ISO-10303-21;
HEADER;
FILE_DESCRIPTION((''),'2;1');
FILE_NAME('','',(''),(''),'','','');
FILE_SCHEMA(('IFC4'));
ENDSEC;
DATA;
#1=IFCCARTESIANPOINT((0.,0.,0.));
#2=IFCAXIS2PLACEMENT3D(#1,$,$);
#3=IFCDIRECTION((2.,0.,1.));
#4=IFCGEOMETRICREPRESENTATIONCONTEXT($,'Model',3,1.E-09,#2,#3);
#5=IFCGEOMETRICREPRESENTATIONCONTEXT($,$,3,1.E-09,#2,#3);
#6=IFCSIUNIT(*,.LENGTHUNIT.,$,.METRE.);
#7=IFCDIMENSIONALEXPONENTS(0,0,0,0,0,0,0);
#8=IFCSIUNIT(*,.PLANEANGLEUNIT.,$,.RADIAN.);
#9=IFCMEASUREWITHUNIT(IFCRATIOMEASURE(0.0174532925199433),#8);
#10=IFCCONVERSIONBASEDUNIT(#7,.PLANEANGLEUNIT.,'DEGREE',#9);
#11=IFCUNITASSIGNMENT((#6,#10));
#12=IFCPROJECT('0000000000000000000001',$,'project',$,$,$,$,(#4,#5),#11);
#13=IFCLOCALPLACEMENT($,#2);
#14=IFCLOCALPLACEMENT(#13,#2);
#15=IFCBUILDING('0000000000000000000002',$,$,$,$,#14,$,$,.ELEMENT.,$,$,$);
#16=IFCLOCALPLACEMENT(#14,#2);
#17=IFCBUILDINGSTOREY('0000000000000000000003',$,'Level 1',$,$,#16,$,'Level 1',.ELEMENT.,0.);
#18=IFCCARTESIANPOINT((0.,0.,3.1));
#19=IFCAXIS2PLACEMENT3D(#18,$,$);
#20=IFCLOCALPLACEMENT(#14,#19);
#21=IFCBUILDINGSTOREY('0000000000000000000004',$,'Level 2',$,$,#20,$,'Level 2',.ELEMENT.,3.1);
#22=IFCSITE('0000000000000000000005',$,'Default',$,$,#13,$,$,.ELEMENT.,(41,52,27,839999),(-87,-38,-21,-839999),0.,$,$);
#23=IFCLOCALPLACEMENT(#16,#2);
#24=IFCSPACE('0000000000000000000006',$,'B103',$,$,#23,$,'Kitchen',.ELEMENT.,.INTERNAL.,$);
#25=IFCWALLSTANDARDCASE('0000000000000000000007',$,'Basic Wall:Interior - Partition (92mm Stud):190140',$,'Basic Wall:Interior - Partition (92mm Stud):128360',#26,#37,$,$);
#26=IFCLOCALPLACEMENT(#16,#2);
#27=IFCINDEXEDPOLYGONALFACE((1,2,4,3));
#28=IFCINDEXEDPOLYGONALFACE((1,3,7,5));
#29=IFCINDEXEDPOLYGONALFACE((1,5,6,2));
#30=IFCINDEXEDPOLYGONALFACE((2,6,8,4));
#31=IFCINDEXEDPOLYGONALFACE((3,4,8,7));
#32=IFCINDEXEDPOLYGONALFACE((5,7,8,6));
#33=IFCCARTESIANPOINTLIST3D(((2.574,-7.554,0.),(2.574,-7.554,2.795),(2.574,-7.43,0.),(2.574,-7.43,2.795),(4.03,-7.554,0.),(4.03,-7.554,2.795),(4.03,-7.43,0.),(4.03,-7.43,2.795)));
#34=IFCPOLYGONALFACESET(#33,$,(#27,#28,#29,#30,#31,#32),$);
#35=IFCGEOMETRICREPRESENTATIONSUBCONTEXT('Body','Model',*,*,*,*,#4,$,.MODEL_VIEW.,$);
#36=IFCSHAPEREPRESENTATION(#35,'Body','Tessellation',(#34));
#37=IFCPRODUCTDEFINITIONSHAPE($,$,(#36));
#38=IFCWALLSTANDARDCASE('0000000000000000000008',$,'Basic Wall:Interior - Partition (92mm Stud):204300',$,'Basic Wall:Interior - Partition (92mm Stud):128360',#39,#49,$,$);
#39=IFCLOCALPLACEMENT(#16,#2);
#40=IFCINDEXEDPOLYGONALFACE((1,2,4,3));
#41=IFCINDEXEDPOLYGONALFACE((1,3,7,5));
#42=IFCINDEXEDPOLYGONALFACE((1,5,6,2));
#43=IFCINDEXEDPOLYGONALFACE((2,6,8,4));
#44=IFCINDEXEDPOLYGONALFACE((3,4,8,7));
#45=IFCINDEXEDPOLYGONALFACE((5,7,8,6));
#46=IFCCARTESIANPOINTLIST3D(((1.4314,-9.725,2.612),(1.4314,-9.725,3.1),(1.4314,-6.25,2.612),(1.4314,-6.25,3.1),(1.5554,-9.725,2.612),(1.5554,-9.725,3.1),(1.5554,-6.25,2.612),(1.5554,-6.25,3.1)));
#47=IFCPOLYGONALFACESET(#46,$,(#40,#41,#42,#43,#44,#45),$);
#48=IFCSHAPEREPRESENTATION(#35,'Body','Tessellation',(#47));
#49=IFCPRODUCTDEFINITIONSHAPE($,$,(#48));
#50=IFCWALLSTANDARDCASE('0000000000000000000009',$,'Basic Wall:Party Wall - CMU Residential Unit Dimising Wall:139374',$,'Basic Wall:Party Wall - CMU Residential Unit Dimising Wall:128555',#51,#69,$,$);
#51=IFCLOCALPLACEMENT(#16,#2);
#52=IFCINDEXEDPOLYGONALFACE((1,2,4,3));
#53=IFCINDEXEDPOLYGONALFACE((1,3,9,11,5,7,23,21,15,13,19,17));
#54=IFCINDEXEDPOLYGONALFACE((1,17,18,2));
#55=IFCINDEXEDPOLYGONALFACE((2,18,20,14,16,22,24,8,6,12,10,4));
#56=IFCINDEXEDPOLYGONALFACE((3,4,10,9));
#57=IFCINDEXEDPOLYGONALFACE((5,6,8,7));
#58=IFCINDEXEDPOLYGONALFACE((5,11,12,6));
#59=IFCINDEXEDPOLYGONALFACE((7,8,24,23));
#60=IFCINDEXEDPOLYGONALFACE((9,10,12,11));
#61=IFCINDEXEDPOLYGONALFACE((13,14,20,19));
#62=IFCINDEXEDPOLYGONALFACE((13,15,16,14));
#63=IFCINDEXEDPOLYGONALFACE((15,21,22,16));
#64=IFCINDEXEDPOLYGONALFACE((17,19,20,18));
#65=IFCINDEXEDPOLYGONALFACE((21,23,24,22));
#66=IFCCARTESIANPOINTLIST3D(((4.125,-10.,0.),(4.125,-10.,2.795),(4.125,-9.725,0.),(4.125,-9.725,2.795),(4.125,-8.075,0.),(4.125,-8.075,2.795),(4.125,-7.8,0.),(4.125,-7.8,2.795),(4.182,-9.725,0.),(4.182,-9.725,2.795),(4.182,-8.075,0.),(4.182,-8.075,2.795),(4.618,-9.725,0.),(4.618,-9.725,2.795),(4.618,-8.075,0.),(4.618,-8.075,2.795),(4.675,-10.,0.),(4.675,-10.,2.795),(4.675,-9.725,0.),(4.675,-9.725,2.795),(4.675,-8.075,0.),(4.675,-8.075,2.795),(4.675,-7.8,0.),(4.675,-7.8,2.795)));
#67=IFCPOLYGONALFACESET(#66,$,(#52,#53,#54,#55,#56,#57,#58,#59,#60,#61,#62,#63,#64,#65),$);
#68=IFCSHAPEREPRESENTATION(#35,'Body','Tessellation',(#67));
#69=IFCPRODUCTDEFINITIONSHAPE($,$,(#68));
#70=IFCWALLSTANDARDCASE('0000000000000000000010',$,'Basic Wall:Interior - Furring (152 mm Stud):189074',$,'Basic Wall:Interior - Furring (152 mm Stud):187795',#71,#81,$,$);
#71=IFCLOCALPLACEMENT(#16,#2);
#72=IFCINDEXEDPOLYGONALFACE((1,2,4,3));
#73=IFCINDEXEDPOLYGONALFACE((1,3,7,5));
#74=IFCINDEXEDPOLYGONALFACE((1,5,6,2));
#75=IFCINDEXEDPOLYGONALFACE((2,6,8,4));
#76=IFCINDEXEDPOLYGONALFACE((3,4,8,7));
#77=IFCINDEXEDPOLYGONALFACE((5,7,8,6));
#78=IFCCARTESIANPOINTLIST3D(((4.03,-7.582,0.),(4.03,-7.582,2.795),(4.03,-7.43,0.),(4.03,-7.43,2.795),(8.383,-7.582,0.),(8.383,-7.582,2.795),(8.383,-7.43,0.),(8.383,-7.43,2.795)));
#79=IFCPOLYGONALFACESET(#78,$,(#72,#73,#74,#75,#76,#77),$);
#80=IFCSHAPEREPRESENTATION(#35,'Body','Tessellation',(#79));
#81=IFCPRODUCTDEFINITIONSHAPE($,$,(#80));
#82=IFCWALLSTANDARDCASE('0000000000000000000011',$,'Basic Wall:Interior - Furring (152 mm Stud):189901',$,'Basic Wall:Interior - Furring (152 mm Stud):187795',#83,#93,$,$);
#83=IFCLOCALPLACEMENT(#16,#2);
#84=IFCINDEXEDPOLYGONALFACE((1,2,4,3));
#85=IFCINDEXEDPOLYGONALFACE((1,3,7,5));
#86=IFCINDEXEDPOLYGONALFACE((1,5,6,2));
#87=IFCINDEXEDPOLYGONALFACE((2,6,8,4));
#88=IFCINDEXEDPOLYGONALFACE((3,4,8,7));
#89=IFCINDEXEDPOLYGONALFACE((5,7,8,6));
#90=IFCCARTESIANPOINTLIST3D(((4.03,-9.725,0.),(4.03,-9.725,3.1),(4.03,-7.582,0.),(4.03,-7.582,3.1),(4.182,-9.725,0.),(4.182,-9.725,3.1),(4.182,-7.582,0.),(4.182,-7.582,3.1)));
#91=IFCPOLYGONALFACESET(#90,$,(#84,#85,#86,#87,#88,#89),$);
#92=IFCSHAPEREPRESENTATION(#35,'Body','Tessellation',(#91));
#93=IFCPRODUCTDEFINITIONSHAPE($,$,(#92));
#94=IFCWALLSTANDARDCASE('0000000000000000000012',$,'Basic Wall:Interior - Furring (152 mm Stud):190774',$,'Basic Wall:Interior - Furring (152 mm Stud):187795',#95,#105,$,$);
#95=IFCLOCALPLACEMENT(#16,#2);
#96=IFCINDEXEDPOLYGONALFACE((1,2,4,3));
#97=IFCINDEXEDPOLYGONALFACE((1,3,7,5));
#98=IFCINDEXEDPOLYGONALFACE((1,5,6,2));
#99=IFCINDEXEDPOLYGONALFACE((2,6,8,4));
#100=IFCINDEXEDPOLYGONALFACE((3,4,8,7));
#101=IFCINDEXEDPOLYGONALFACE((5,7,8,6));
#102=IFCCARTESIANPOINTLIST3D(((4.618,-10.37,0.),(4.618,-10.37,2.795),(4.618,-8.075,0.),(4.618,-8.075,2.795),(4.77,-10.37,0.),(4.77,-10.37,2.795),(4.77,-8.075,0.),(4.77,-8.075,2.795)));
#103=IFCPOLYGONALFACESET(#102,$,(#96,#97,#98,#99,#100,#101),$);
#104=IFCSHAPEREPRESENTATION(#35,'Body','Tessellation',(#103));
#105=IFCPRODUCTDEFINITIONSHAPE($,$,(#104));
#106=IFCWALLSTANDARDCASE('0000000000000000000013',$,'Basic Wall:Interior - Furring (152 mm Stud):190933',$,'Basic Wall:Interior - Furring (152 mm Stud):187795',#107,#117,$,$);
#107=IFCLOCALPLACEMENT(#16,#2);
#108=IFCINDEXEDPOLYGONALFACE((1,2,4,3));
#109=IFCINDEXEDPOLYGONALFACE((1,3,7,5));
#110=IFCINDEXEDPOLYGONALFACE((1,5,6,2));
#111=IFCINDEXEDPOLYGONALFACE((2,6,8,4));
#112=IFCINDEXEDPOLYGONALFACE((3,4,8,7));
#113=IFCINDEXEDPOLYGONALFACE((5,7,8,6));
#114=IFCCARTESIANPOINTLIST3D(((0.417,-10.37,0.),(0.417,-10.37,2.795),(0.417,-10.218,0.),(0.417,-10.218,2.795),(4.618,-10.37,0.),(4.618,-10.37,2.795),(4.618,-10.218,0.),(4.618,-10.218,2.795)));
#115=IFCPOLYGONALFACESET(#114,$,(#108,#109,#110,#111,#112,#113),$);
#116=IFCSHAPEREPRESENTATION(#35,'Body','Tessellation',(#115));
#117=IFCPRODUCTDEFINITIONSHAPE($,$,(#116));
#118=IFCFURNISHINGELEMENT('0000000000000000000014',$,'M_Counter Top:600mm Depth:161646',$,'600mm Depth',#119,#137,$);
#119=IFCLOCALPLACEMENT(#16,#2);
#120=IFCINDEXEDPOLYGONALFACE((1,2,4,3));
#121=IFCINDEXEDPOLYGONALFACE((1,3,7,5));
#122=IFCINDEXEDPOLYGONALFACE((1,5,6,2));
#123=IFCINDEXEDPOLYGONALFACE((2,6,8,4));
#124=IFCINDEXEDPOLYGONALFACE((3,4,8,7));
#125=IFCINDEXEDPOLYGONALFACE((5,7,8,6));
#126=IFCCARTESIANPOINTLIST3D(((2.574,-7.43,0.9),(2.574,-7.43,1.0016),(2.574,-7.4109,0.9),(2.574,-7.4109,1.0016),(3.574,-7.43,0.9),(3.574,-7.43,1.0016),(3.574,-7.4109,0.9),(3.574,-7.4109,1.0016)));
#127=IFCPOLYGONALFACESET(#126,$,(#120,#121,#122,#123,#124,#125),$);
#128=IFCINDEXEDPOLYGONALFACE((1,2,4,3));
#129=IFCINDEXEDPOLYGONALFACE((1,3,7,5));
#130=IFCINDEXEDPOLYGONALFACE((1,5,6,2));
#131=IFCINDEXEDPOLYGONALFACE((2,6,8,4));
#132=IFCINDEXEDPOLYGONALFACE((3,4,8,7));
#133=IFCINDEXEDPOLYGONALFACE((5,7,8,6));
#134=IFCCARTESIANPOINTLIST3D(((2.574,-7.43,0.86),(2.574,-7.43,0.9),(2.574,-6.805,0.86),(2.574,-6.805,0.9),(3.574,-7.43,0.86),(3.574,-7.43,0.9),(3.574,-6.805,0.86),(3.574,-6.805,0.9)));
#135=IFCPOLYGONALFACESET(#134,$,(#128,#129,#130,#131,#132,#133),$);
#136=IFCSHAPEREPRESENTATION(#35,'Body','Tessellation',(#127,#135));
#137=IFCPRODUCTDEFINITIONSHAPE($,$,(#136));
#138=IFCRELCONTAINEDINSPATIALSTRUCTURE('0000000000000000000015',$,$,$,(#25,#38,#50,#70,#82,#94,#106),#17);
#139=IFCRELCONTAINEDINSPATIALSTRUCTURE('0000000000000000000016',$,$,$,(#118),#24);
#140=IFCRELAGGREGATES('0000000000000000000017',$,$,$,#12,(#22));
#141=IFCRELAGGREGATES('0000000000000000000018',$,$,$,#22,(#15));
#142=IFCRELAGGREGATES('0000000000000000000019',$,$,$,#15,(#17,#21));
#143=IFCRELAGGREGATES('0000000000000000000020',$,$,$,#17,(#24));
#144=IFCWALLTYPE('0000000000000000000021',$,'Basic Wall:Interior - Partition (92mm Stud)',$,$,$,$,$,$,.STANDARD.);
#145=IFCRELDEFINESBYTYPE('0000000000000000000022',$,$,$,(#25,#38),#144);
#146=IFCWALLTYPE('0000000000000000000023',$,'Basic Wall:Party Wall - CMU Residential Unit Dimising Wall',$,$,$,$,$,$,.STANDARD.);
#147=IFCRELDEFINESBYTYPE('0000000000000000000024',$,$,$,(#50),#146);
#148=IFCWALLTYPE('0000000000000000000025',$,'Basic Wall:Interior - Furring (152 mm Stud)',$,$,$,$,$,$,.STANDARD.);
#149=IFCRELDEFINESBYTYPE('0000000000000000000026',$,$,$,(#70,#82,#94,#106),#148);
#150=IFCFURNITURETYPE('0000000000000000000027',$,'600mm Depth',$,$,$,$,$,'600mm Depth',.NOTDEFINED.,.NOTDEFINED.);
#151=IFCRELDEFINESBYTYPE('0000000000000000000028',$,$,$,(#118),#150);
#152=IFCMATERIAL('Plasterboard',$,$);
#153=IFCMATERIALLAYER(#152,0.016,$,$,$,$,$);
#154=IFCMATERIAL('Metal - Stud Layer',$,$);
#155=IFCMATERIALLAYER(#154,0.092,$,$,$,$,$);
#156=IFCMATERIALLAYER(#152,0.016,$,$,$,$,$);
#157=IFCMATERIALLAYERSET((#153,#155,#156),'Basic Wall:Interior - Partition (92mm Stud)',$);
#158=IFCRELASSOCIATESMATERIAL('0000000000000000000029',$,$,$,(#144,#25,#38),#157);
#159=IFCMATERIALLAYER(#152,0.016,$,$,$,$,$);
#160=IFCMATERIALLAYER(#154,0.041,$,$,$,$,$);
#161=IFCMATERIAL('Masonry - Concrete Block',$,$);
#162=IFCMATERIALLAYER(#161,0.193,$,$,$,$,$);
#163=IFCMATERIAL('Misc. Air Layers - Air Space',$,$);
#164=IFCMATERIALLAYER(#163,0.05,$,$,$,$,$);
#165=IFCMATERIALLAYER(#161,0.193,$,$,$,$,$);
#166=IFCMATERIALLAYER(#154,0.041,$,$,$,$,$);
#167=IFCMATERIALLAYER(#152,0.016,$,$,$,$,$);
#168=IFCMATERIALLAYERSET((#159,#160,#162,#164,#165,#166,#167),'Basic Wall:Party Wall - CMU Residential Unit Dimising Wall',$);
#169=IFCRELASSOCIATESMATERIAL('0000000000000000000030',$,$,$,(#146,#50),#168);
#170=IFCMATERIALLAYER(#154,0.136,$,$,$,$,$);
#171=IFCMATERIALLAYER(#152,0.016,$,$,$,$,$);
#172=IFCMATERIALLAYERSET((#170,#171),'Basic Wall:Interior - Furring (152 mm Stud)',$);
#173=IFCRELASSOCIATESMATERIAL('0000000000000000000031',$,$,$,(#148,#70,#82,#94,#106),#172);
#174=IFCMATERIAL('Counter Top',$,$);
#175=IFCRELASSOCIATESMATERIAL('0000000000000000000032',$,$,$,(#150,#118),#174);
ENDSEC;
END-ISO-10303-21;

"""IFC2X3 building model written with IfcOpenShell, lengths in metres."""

from ifc_helpers import new_model, entity, si_unit, converted_unit, direction, frame, frame_2d, origin, place, context, subcontext, project, spatial, polyline, rectangle, extrude, clip, bounded_halfspace, source, transform, mapped, material, layer, layer_set, layer_usage, type_object, type_shapes, element, save


model = new_model("IFC2X3")

# Units and contexts
model_context = context("Model", 3, precision=1e-09, world=origin(), true_north=direction((2.0, 0.0, 1.0)))
context_of_model = context(None, 3, precision=1e-09, world=origin(), true_north=direction((2.0, 0.0, 1.0)))
body_context = subcontext(model_context, "Body", "Model", "MODEL_VIEW")
ifc_project = project(units=[si_unit("LENGTHUNIT", "METRE"), converted_unit("PLANEANGLEUNIT", "DEGREE", entity("IfcRatioMeasure", 0.0174532925199433), si_unit("PLANEANGLEUNIT", "RADIAN"), dimensions=[0, 0, 0, 0, 0, 0, 0])], contexts=[model_context, context_of_model])

# Site, building, storey
site_placement = place(None, origin())
site = spatial("IfcSite", under=ifc_project, at=site_placement, Name="Default", CompositionType="ELEMENT", RefLatitude=(41, 52, 27, 839999), RefLongitude=(-87, -38, -21, -839999), RefElevation=0.0)
building_placement = place(site_placement, origin())
building = spatial("IfcBuilding", under=site, at=building_placement, CompositionType="ELEMENT")
storey_1_placement = place(building_placement, origin())
storey_1 = spatial("IfcBuildingStorey", under=building, at=storey_1_placement, Name="Level 1", LongName="Level 1", CompositionType="ELEMENT", Elevation=0.0)

# Shared definitions
ifc_material_1 = material(Name="Plasterboard")
ifc_layer_1 = layer(ifc_material_1, 0.016)
ifc_material_2 = material(Name="Metal - Stud Layer")
ifc_layer_2 = layer(ifc_material_2, 0.092)
ifc_layer_3 = layer(ifc_material_1, 0.016)
ifc_layer_set_1 = layer_set([ifc_layer_1, ifc_layer_2, ifc_layer_3], Name="Basic Wall:Interior - Partition (92mm Stud)")
wall_type_1 = type_object("IfcWallType", Name="Basic Wall:Interior - Partition (92mm Stud)", PredefinedType="STANDARD", material=ifc_layer_set_1)

# Shared definitions
storey_2_placement = place(building_placement, frame((0.0, 0.0, 3.1)))
storey_2 = spatial("IfcBuildingStorey", under=building, at=storey_2_placement, Name="Level 2", LongName="Level 2", CompositionType="ELEMENT", Elevation=3.1)

# Walls
ifc_layer_usage_1 = layer_usage(ifc_layer_set_1, "AXIS2", "NEGATIVE", 0.062)
wall_1_placement = place(storey_1_placement, frame((4.03, -7.492, 0.0), z_axis=(0.0, 0.0, 1.0), x_axis=(-1.0, 0.0, 0.0)))
element("IfcWallStandardCase", 1, at=wall_1_placement, inside=storey_1, type_object=wall_type_1, material=ifc_layer_usage_1, Name="Basic Wall:Interior - Partition (92mm Stud):190140", ObjectType="Basic Wall:Interior - Partition (92mm Stud):128360", context=body_context, shape_type="SweptSolid", body=[
    extrude(rectangle(XDim=1.456, YDim=0.124, at=frame_2d((0.728, 0.0), x_axis=(-1.0, 0.0))), origin(), (0.0, 0.0, 1.0), 2.795),
])
ifc_layer_usage_2 = layer_usage(ifc_layer_set_1, "AXIS2", "NEGATIVE", 0.062)
wall_2_placement = place(storey_1_placement, frame((1.4934, -6.25, 2.612), z_axis=(0.0, 0.0, 1.0), x_axis=(0.0, -1.0, 0.0)))
element("IfcWallStandardCase", 2, at=wall_2_placement, inside=storey_1, type_object=wall_type_1, material=ifc_layer_usage_2, Name="Basic Wall:Interior - Partition (92mm Stud):204300", ObjectType="Basic Wall:Interior - Partition (92mm Stud):128360", context=body_context, shape_type="SweptSolid", body=[
    extrude(rectangle(XDim=3.475, YDim=0.124, at=frame_2d((1.7375, 0.0), x_axis=(-1.0, 0.0))), origin(), (0.0, 0.0, 1.0), 0.488),
])
ifc_layer_4 = layer(ifc_material_1, 0.016)
ifc_layer_5 = layer(ifc_material_2, 0.041)
ifc_material_3 = material(Name="Masonry - Concrete Block")
ifc_layer_6 = layer(ifc_material_3, 0.193)
ifc_material_4 = material(Name="Misc. Air Layers - Air Space")
ifc_layer_7 = layer(ifc_material_4, 0.05)
ifc_layer_8 = layer(ifc_material_3, 0.193)
ifc_layer_9 = layer(ifc_material_2, 0.041)
ifc_layer_10 = layer(ifc_material_1, 0.016)
ifc_layer_set_2 = layer_set([ifc_layer_4, ifc_layer_5, ifc_layer_6, ifc_layer_7, ifc_layer_8, ifc_layer_9, ifc_layer_10], Name="Basic Wall:Party Wall - CMU Residential Unit Dimising Wall")
wall_type_2 = type_object("IfcWallType", Name="Basic Wall:Party Wall - CMU Residential Unit Dimising Wall", PredefinedType="STANDARD", material=ifc_layer_set_2)
ifc_layer_usage_3 = layer_usage(ifc_layer_set_2, "AXIS2", "NEGATIVE", 0.275)
wall_3_placement = place(storey_1_placement, frame((4.4, -10.0, 0.0), z_axis=(0.0, 0.0, 1.0), x_axis=(0.0, 1.0, 0.0)))
element("IfcWallStandardCase", 3, at=wall_3_placement, inside=storey_1, type_object=wall_type_2, material=ifc_layer_usage_3, Name="Basic Wall:Party Wall - CMU Residential Unit Dimising Wall:139374", ObjectType="Basic Wall:Party Wall - CMU Residential Unit Dimising Wall:128555", context=body_context, shape_type="Clipping", body=[
    clip(clip(extrude(rectangle(XDim=2.2, YDim=0.55, at=frame_2d((1.1, 0.0), x_axis=(-1.0, 0.0))), origin(), (0.0, 0.0, 1.0), 2.795), bounded_halfspace(frame((1.925, 0.218, 0.0), z_axis=(0.0, -1.0, 0.0), x_axis=(1.0, 0.0, 0.0)), True, frame((1.925, 0.218, 0.0), z_axis=(0.0, -1.0, 0.0), x_axis=(1.0, 0.0, 0.0)), polyline([(0.0, 0.0), (0.0, 2.795), (-1.65, 2.795), (-1.65, 0.0), (0.0, 0.0)]))), bounded_halfspace(frame((0.275, -0.218, 0.0), z_axis=(0.0, 1.0, 0.0), x_axis=(-1.0, 0.0, 0.0)), True, frame((0.275, -0.218, 0.0), z_axis=(0.0, 1.0, 0.0), x_axis=(-1.0, 0.0, 0.0)), polyline([(0.0, 0.0), (0.0, 2.795), (-1.65, 2.795), (-1.65, 0.0), (0.0, 0.0)]))),
])
ifc_layer_11 = layer(ifc_material_2, 0.136)
ifc_layer_12 = layer(ifc_material_1, 0.016)
ifc_layer_set_3 = layer_set([ifc_layer_11, ifc_layer_12], Name="Basic Wall:Interior - Furring (152 mm Stud)")
ifc_layer_usage_4 = layer_usage(ifc_layer_set_3, "AXIS2", "NEGATIVE", 0.076)
wall_type_3 = type_object("IfcWallType", Name="Basic Wall:Interior - Furring (152 mm Stud)", PredefinedType="STANDARD", material=ifc_layer_set_3)
wall_4_placement = place(storey_1_placement, frame((8.383, -7.506, 0.0), z_axis=(0.0, 0.0, 1.0), x_axis=(-1.0, 0.0, 0.0)))
element("IfcWallStandardCase", 4, at=wall_4_placement, inside=storey_1, type_object=wall_type_3, material=ifc_layer_usage_4, Name="Basic Wall:Interior - Furring (152 mm Stud):189074", ObjectType="Basic Wall:Interior - Furring (152 mm Stud):187795", context=body_context, shape_type="Clipping", body=[
    clip(extrude(rectangle(XDim=4.353, YDim=0.152, at=frame_2d((2.1765, 0.0), x_axis=(-1.0, 0.0))), origin(), (0.0, 0.0, 1.0), 2.795), bounded_halfspace(frame((0.0, -0.076, 2.795), z_axis=(0.0, 0.0, -1.0), x_axis=(0.0, 1.0, 0.0)), True, frame((0.0, -0.076, 2.795)), polyline([(0.0, 0.0), (3.708, 0.0), (3.708, 0.152), (0.0, 0.152), (0.0, 0.0)]))),
])
ifc_layer_usage_5 = layer_usage(ifc_layer_set_3, "AXIS2", "POSITIVE", -0.076)
wall_5_placement = place(storey_1_placement, frame((4.106, -9.725, 0.0), z_axis=(0.0, 0.0, 1.0), x_axis=(0.0, 1.0, 0.0)))
element("IfcWallStandardCase", 5, at=wall_5_placement, inside=storey_1, type_object=wall_type_3, material=ifc_layer_usage_5, Name="Basic Wall:Interior - Furring (152 mm Stud):189901", ObjectType="Basic Wall:Interior - Furring (152 mm Stud):187795", context=body_context, shape_type="SweptSolid", body=[
    extrude(rectangle(XDim=2.143, YDim=0.152, at=frame_2d((1.0715, 0.0), x_axis=(-1.0, 0.0))), origin(), (0.0, 0.0, 1.0), 3.1),
])
ifc_layer_usage_6 = layer_usage(ifc_layer_set_3, "AXIS2", "POSITIVE", -0.076)
wall_6_placement = place(storey_1_placement, frame((4.694, -8.075, 0.0), z_axis=(0.0, 0.0, 1.0), x_axis=(0.0, -1.0, 0.0)))
element("IfcWallStandardCase", 6, at=wall_6_placement, inside=storey_1, type_object=wall_type_3, material=ifc_layer_usage_6, Name="Basic Wall:Interior - Furring (152 mm Stud):190774", ObjectType="Basic Wall:Interior - Furring (152 mm Stud):187795", context=body_context, shape_type="SweptSolid", body=[
    extrude(rectangle(XDim=2.295, YDim=0.152, at=frame_2d((1.1475, 0.0), x_axis=(-1.0, 0.0))), origin(), (0.0, 0.0, 1.0), 2.795),
])
ifc_layer_usage_7 = layer_usage(ifc_layer_set_3, "AXIS2", "NEGATIVE", 0.076)
wall_7_placement = place(storey_1_placement, frame((0.417, -10.294, 0.0)))
element("IfcWallStandardCase", 7, at=wall_7_placement, inside=storey_1, type_object=wall_type_3, material=ifc_layer_usage_7, Name="Basic Wall:Interior - Furring (152 mm Stud):190933", ObjectType="Basic Wall:Interior - Furring (152 mm Stud):187795", context=body_context, shape_type="SweptSolid", body=[
    extrude(rectangle(XDim=4.201, YDim=0.152, at=frame_2d((2.1005, 0.0), x_axis=(-1.0, 0.0))), origin(), (0.0, 0.0, 1.0), 2.795),
])

# Shared definitions
space_placement = place(storey_1_placement, origin())
space = spatial("IfcSpace", under=storey_1, at=space_placement, Name="B103", LongName="Kitchen", CompositionType="ELEMENT", InteriorOrExteriorSpace="INTERNAL")

# Shared definitions
ifc_material_5 = material(Name="Counter Top")

# Furnishing element
furniture_type_1 = type_object("IfcFurnitureType", Name="600mm Depth", ElementType="600mm Depth", AssemblyPlace="NOTDEFINED", material=ifc_material_5)
shared_shape_1 = source(origin(), body_context, "Body", "SweptSolid", [
    extrude(rectangle(XDim=0.0191, YDim=1.0, at=frame_2d((0.0, 0.0), x_axis=(1.0, 0.0))), frame((-0.7005, -0.0095, 0.9), z_axis=(0.0, 0.0, 1.0), x_axis=(0.0, -1.0, 0.0)), (0.0, 0.0, 1.0), 0.1016),
    extrude(rectangle(XDim=1.0, YDim=0.625, at=frame_2d((0.0, 0.0), x_axis=(1.0, 0.0))), frame((-0.7005, -0.3125, 0.86), z_axis=(0.0, 0.0, 1.0), x_axis=(-1.0, 0.0, 0.0)), (0.0, 0.0, 1.0), 0.04),
])
type_shapes(furniture_type_1, [shared_shape_1])
furnishing_1_placement = place(space_placement, frame((2.3735, -7.43, 0.0), z_axis=(0.0, 0.0, 1.0), x_axis=(-1.0, 0.0, 0.0)))
element("IfcFurnishingElement", 8, at=furnishing_1_placement, inside=space, type_object=furniture_type_1, material=ifc_material_5, Name="M_Counter Top:600mm Depth:161646", ObjectType="600mm Depth", context=body_context, shape_type="MappedRepresentation", body=[
    mapped(shared_shape_1, transform((0.0, 0.0, 0.0), scale=1.0)),
])

save(model, "model.ifc")
